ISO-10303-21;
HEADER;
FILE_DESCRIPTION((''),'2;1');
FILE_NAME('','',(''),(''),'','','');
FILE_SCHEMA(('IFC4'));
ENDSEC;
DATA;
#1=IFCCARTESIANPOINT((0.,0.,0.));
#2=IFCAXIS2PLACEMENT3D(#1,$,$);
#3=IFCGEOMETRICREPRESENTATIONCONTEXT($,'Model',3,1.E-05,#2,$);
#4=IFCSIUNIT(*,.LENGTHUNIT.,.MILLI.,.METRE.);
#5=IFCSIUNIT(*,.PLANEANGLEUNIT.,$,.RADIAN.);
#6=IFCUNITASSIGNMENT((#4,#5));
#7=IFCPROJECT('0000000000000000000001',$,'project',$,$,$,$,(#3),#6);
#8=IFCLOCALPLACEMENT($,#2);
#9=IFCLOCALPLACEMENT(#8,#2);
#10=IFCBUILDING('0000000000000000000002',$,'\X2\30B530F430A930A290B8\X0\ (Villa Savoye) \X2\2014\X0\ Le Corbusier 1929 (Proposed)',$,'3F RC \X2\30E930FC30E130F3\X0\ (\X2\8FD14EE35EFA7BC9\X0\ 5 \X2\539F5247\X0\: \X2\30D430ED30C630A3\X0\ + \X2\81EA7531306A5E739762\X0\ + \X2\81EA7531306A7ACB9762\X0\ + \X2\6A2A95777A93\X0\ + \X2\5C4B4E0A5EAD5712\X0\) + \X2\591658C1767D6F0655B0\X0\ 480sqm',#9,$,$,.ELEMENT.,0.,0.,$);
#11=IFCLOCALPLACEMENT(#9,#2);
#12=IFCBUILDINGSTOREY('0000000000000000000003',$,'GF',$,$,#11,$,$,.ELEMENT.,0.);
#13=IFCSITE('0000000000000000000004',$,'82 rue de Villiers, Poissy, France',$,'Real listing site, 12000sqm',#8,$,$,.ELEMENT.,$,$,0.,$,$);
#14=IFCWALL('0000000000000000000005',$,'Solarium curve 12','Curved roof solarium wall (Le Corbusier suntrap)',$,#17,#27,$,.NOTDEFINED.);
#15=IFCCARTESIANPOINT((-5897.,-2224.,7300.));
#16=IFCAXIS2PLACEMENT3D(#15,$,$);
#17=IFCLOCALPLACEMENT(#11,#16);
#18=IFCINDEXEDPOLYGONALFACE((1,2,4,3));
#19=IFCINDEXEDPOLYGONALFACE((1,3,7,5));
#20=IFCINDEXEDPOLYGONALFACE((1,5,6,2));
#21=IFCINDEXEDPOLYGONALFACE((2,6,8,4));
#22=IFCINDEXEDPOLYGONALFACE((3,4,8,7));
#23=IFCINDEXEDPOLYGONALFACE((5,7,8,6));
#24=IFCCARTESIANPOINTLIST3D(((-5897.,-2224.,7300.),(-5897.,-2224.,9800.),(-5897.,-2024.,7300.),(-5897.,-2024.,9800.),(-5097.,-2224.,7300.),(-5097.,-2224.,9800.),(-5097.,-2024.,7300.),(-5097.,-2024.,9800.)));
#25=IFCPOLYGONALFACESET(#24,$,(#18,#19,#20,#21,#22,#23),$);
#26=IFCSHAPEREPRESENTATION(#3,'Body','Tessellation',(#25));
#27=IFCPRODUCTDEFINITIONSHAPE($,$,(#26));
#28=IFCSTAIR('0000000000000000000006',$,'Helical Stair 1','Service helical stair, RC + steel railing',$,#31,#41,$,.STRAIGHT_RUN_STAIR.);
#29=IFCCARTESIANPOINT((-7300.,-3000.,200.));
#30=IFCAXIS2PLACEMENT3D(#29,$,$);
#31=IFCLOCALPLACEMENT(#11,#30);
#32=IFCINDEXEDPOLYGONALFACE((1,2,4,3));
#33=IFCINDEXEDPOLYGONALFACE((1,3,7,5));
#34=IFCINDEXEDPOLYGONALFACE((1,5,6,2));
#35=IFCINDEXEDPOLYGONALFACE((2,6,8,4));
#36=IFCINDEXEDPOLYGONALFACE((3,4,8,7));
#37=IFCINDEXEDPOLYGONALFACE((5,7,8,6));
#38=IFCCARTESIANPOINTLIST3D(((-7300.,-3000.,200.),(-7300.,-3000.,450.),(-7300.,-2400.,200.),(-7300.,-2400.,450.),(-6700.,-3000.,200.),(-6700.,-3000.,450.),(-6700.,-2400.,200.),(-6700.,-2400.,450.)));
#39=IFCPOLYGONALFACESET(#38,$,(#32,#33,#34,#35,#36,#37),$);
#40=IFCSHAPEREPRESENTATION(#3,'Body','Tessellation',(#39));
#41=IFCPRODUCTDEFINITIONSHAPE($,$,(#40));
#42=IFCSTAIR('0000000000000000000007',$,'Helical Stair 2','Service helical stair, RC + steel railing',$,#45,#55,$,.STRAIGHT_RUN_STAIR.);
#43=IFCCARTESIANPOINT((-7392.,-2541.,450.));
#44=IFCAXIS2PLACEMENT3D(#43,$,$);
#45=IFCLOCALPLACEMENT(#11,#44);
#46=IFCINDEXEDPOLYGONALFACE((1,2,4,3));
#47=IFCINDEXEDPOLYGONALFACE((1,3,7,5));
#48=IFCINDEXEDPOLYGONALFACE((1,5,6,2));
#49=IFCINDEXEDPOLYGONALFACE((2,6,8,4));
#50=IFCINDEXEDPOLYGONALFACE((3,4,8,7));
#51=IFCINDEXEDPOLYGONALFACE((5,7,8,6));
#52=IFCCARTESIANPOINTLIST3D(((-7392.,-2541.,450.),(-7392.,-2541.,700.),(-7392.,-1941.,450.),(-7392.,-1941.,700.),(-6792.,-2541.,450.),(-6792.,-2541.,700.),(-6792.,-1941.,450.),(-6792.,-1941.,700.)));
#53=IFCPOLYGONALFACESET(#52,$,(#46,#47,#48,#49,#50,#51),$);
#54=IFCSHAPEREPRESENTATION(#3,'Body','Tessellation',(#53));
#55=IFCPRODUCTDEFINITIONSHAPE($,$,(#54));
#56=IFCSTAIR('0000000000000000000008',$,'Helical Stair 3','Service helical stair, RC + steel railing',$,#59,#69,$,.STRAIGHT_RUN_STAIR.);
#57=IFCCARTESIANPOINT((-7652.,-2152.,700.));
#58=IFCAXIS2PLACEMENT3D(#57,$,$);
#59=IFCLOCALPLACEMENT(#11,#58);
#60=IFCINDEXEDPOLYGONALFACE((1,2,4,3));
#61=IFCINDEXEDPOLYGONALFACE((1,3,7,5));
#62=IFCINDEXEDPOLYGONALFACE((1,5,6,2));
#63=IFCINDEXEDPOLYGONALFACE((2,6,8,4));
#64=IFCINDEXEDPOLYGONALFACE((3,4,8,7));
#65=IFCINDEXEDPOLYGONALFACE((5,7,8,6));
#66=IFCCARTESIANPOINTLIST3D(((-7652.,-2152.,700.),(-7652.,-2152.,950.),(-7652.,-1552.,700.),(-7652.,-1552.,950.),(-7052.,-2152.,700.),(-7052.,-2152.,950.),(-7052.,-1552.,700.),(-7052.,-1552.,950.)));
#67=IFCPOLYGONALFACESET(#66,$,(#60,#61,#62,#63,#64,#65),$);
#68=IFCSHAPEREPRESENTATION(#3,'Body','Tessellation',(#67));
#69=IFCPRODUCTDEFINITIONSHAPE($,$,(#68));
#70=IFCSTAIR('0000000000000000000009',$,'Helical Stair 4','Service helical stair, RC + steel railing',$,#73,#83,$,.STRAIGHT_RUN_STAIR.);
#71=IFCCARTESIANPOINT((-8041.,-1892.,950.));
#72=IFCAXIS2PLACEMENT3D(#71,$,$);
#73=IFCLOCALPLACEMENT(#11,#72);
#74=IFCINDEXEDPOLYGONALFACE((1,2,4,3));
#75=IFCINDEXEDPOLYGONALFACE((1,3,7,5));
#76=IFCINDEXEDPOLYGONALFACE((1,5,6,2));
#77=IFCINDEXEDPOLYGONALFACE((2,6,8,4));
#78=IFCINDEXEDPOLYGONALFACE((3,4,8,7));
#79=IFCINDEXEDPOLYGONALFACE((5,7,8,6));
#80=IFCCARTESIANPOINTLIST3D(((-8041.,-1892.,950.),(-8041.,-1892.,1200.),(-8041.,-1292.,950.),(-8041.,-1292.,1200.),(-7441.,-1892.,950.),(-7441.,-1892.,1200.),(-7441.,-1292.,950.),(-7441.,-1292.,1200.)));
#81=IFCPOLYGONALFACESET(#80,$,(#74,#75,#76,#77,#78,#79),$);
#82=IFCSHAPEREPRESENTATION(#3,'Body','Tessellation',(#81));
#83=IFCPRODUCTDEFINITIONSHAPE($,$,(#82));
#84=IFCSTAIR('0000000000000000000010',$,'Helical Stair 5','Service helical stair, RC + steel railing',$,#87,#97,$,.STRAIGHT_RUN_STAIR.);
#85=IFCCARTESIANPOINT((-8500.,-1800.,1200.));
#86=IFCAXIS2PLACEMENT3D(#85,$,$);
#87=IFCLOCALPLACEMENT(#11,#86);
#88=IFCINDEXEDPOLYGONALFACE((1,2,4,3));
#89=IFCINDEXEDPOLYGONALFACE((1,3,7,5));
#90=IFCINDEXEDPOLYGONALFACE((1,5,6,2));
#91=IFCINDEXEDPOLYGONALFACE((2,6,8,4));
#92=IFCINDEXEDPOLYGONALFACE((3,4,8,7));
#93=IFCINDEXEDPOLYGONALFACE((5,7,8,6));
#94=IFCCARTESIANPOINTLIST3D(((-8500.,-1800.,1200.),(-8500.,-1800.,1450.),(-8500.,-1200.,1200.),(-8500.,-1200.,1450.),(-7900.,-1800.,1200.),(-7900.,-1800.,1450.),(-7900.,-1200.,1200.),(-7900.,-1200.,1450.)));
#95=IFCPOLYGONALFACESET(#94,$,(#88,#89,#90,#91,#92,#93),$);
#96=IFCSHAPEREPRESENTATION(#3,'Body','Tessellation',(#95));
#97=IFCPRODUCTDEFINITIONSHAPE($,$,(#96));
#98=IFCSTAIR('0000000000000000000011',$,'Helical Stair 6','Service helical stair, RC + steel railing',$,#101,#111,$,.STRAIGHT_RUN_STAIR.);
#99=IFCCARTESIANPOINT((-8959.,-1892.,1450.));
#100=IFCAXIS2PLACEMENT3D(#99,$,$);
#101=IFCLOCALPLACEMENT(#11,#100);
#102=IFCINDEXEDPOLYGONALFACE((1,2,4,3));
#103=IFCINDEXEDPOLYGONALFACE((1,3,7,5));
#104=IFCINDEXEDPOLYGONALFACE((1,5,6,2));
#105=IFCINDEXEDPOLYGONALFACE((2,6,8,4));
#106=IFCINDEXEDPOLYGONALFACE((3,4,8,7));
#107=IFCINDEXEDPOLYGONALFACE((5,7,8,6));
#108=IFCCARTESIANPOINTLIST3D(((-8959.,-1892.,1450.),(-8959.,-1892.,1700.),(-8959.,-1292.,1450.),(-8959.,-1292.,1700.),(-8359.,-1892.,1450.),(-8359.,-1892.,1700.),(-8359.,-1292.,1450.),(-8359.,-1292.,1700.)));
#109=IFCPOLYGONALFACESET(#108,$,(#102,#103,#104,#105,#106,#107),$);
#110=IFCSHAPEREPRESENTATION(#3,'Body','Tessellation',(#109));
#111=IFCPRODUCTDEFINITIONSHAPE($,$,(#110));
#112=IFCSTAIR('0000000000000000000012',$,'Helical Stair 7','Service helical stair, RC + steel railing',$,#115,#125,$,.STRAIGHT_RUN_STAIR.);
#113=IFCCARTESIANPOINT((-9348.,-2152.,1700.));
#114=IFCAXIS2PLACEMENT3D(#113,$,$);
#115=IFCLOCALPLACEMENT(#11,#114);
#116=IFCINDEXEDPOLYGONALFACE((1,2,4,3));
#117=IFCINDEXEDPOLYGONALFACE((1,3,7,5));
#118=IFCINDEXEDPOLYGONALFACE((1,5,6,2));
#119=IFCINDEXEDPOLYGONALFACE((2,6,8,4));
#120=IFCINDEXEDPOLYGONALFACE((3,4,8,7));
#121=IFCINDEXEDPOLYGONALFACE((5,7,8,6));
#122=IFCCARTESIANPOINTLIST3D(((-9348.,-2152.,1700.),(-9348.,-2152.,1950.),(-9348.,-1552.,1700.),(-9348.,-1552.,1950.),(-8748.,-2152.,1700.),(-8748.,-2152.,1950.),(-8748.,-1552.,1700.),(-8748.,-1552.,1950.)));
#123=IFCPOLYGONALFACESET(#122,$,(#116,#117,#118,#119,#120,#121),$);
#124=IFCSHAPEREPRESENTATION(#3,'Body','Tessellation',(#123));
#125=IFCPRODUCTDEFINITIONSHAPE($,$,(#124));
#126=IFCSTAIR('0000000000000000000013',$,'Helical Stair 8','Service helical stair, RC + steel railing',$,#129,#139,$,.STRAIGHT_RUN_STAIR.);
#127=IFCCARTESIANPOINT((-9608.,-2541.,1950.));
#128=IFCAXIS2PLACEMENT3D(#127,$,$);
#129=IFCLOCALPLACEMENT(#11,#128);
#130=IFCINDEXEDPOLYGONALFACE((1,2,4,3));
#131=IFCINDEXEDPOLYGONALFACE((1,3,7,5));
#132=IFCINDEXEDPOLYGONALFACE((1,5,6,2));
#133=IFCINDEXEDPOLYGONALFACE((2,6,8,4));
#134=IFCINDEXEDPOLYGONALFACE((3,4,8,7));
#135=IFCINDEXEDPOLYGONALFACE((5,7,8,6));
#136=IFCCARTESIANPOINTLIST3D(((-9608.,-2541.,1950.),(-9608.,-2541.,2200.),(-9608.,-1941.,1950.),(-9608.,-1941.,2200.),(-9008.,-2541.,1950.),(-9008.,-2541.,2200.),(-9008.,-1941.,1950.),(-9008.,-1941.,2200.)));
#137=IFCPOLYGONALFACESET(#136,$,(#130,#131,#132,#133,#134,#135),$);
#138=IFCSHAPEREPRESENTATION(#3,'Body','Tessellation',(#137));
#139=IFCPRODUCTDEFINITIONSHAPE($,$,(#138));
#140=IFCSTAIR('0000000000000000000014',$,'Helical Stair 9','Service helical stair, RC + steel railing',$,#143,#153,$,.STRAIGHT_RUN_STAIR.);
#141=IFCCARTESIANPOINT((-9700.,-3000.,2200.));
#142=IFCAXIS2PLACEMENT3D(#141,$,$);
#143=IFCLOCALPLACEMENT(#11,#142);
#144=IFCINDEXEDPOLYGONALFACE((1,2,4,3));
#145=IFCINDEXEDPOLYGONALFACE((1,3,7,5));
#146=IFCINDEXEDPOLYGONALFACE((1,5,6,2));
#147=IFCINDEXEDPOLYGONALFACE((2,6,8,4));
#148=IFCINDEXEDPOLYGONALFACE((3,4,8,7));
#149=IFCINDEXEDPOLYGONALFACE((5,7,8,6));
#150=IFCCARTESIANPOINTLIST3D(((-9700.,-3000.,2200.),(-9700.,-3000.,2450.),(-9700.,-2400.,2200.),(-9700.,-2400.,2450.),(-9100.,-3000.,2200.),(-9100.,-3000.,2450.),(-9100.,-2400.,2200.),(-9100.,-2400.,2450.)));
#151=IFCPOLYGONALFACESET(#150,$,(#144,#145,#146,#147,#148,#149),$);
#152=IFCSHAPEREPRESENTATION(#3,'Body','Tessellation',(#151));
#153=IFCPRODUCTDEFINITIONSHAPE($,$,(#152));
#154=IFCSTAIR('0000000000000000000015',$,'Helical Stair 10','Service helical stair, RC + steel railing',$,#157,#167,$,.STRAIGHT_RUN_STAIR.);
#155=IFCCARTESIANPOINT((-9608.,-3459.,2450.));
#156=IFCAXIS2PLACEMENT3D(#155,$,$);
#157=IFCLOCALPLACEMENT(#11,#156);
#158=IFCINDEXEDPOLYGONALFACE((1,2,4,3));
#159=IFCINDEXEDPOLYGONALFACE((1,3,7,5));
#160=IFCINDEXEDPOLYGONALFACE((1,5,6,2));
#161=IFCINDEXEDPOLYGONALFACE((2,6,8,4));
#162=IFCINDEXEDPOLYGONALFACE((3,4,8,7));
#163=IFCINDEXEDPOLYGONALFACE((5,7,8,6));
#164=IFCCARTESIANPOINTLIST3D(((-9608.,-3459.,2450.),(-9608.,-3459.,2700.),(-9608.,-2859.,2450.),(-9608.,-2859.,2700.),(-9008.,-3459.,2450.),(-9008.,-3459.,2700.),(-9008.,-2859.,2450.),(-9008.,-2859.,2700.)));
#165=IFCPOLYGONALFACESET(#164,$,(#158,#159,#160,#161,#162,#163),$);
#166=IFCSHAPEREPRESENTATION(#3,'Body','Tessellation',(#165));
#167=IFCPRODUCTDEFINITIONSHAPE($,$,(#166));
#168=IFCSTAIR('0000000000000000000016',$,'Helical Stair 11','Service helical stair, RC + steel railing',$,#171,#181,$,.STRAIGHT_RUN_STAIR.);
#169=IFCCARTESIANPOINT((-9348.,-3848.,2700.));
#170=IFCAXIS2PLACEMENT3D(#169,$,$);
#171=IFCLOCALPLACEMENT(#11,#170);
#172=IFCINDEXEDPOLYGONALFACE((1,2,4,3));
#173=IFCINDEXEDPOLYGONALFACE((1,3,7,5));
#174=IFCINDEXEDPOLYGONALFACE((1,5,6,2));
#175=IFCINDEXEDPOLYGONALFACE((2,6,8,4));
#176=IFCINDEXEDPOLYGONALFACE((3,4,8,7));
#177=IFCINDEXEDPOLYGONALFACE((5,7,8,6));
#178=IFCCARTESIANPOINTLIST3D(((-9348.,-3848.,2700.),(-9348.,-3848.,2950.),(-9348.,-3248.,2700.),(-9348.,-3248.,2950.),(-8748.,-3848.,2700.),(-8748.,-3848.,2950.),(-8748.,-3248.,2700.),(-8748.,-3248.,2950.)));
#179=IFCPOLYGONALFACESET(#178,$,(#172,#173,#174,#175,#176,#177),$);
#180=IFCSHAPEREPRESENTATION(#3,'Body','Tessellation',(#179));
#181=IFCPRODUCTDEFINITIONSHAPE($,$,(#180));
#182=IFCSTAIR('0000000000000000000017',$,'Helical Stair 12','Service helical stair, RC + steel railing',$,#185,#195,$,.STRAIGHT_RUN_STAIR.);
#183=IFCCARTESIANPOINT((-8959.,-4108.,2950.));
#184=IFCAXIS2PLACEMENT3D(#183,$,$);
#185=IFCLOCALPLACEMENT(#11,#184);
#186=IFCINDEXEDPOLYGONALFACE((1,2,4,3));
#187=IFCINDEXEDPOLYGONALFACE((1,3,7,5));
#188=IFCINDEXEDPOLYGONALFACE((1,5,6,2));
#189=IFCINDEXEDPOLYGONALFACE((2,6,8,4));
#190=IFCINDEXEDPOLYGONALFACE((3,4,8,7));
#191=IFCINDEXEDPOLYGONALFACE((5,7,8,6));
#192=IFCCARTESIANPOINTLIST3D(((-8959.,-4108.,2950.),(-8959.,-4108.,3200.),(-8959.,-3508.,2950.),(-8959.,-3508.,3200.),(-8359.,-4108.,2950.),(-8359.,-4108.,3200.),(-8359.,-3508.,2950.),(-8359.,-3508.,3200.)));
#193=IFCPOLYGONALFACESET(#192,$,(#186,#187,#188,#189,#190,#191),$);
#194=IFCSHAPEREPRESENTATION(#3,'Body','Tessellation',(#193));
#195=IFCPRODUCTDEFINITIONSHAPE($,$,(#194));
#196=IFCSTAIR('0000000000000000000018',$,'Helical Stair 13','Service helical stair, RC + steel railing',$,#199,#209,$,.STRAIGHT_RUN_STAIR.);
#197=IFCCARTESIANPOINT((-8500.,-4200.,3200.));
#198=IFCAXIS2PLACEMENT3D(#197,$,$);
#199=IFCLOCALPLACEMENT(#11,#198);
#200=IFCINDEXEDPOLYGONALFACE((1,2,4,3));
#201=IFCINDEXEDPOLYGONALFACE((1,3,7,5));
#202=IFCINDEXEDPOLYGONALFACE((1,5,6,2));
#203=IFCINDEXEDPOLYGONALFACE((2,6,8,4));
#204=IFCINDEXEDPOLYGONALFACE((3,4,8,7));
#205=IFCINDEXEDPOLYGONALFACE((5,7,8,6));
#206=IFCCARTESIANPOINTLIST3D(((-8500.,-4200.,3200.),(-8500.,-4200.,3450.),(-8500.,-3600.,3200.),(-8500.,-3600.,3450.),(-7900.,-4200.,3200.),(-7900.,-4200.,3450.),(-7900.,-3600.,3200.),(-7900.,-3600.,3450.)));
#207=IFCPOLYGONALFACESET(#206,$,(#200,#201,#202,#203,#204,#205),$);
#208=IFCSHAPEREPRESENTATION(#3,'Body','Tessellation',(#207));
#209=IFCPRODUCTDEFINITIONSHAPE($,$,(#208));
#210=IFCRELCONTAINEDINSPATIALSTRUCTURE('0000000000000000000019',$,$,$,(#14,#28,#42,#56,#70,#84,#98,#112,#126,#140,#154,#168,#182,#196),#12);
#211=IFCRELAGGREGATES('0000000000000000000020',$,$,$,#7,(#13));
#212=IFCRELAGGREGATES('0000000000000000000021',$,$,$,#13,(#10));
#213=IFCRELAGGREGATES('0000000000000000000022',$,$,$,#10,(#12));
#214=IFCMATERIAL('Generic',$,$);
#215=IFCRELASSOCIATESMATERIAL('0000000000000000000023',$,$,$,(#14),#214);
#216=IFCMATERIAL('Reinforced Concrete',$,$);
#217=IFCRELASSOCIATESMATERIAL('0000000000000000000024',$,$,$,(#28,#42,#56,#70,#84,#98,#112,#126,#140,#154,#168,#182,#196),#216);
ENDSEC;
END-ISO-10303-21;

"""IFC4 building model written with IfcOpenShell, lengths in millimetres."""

from ifc_helpers import new_model, si_unit, frame, frame_2d, origin, place, context, project, spatial, rectangle, extrude, material, element, save


model = new_model("IFC4")

# Units and contexts
model_context = context("Model", 3, precision=1e-05, world=origin())
ifc_project = project(units=[si_unit("LENGTHUNIT", "METRE", prefix="MILLI"), si_unit("PLANEANGLEUNIT", "RADIAN")], contexts=[model_context])

# Site, building, storey
site_placement = place(None, origin())
site = spatial("IfcSite", under=ifc_project, at=site_placement, Name="82 rue de Villiers, Poissy, France", ObjectType="Real listing site, 12000sqm", CompositionType="ELEMENT", RefElevation=0.0)
building_placement = place(site_placement, origin())
building = spatial("IfcBuilding", under=site, at=building_placement, Name="サヴォア邸 (Villa Savoye) — Le Corbusier 1929 (Proposed)", ObjectType="3F RC ラーメン (近代建築 5 原則: ピロティ + 自由な平面 + 自由な立面 + 横長窓 + 屋上庭園) + 外壁白漆喰 480sqm", CompositionType="ELEMENT", ElevationOfRefHeight=0.0, ElevationOfTerrain=0.0)
storey_placement = place(building_placement, origin())
storey = spatial("IfcBuildingStorey", under=building, at=storey_placement, Name="GF", CompositionType="ELEMENT", Elevation=0.0)

# Shared definitions
ifc_material_1 = material(Name="Reinforced Concrete")
ifc_material_2 = material(Name="Generic")

# Wall
wall_1_placement = place(storey_placement, frame((-5897.0, -2224.0, 7300.0)))
element("IfcWall", 1, at=wall_1_placement, inside=storey, material=ifc_material_2, Name="Solarium curve 12", Description="Curved roof solarium wall (Le Corbusier suntrap)", PredefinedType="NOTDEFINED", context=model_context, shape_type="SweptSolid", body=[
    extrude(rectangle(XDim=800.0, YDim=200.0, at=frame_2d((400.0, 100.0))), frame((-5897.0, -2224.0, 7300.0)), (0.0, 0.0, 1.0), 2500.0),
])

# Stairs
stair_1_placement = place(storey_placement, frame((-7300.0, -3000.0, 200.0)))
element("IfcStair", 2, at=stair_1_placement, inside=storey, material=ifc_material_1, Name="Helical Stair 1", Description="Service helical stair, RC + steel railing", PredefinedType="STRAIGHT_RUN_STAIR", context=model_context, shape_type="SweptSolid", body=[
    extrude(rectangle(XDim=600.0, YDim=600.0, at=frame_2d((300.0, 300.0))), frame((-7300.0, -3000.0, 200.0)), (0.0, 0.0, 1.0), 250.0),
])
stair_2_placement = place(storey_placement, frame((-7392.0, -2541.0, 450.0)))
element("IfcStair", 3, at=stair_2_placement, inside=storey, material=ifc_material_1, Name="Helical Stair 2", Description="Service helical stair, RC + steel railing", PredefinedType="STRAIGHT_RUN_STAIR", context=model_context, shape_type="SweptSolid", body=[
    extrude(rectangle(XDim=600.0, YDim=600.0, at=frame_2d((300.0, 300.0))), frame((-7392.0, -2541.0, 450.0)), (0.0, 0.0, 1.0), 250.0),
])
stair_3_placement = place(storey_placement, frame((-7652.0, -2152.0, 700.0)))
element("IfcStair", 4, at=stair_3_placement, inside=storey, material=ifc_material_1, Name="Helical Stair 3", Description="Service helical stair, RC + steel railing", PredefinedType="STRAIGHT_RUN_STAIR", context=model_context, shape_type="SweptSolid", body=[
    extrude(rectangle(XDim=600.0, YDim=600.0, at=frame_2d((300.0, 300.0))), frame((-7652.0, -2152.0, 700.0)), (0.0, 0.0, 1.0), 250.0),
])
stair_4_placement = place(storey_placement, frame((-8041.0, -1892.0, 950.0)))
element("IfcStair", 5, at=stair_4_placement, inside=storey, material=ifc_material_1, Name="Helical Stair 4", Description="Service helical stair, RC + steel railing", PredefinedType="STRAIGHT_RUN_STAIR", context=model_context, shape_type="SweptSolid", body=[
    extrude(rectangle(XDim=600.0, YDim=600.0, at=frame_2d((300.0, 300.0))), frame((-8041.0, -1892.0, 950.0)), (0.0, 0.0, 1.0), 250.0),
])
stair_5_placement = place(storey_placement, frame((-8500.0, -1800.0, 1200.0)))
element("IfcStair", 6, at=stair_5_placement, inside=storey, material=ifc_material_1, Name="Helical Stair 5", Description="Service helical stair, RC + steel railing", PredefinedType="STRAIGHT_RUN_STAIR", context=model_context, shape_type="SweptSolid", body=[
    extrude(rectangle(XDim=600.0, YDim=600.0, at=frame_2d((300.0, 300.0))), frame((-8500.0, -1800.0, 1200.0)), (0.0, 0.0, 1.0), 250.0),
])
stair_6_placement = place(storey_placement, frame((-8959.0, -1892.0, 1450.0)))
element("IfcStair", 7, at=stair_6_placement, inside=storey, material=ifc_material_1, Name="Helical Stair 6", Description="Service helical stair, RC + steel railing", PredefinedType="STRAIGHT_RUN_STAIR", context=model_context, shape_type="SweptSolid", body=[
    extrude(rectangle(XDim=600.0, YDim=600.0, at=frame_2d((300.0, 300.0))), frame((-8959.0, -1892.0, 1450.0)), (0.0, 0.0, 1.0), 250.0),
])
stair_7_placement = place(storey_placement, frame((-9348.0, -2152.0, 1700.0)))
element("IfcStair", 8, at=stair_7_placement, inside=storey, material=ifc_material_1, Name="Helical Stair 7", Description="Service helical stair, RC + steel railing", PredefinedType="STRAIGHT_RUN_STAIR", context=model_context, shape_type="SweptSolid", body=[
    extrude(rectangle(XDim=600.0, YDim=600.0, at=frame_2d((300.0, 300.0))), frame((-9348.0, -2152.0, 1700.0)), (0.0, 0.0, 1.0), 250.0),
])
stair_8_placement = place(storey_placement, frame((-9608.0, -2541.0, 1950.0)))
element("IfcStair", 9, at=stair_8_placement, inside=storey, material=ifc_material_1, Name="Helical Stair 8", Description="Service helical stair, RC + steel railing", PredefinedType="STRAIGHT_RUN_STAIR", context=model_context, shape_type="SweptSolid", body=[
    extrude(rectangle(XDim=600.0, YDim=600.0, at=frame_2d((300.0, 300.0))), frame((-9608.0, -2541.0, 1950.0)), (0.0, 0.0, 1.0), 250.0),
])
stair_9_placement = place(storey_placement, frame((-9700.0, -3000.0, 2200.0)))
element("IfcStair", 10, at=stair_9_placement, inside=storey, material=ifc_material_1, Name="Helical Stair 9", Description="Service helical stair, RC + steel railing", PredefinedType="STRAIGHT_RUN_STAIR", context=model_context, shape_type="SweptSolid", body=[
    extrude(rectangle(XDim=600.0, YDim=600.0, at=frame_2d((300.0, 300.0))), frame((-9700.0, -3000.0, 2200.0)), (0.0, 0.0, 1.0), 250.0),
])
stair_10_placement = place(storey_placement, frame((-9608.0, -3459.0, 2450.0)))
element("IfcStair", 11, at=stair_10_placement, inside=storey, material=ifc_material_1, Name="Helical Stair 10", Description="Service helical stair, RC + steel railing", PredefinedType="STRAIGHT_RUN_STAIR", context=model_context, shape_type="SweptSolid", body=[
    extrude(rectangle(XDim=600.0, YDim=600.0, at=frame_2d((300.0, 300.0))), frame((-9608.0, -3459.0, 2450.0)), (0.0, 0.0, 1.0), 250.0),
])
stair_11_placement = place(storey_placement, frame((-9348.0, -3848.0, 2700.0)))
element("IfcStair", 12, at=stair_11_placement, inside=storey, material=ifc_material_1, Name="Helical Stair 11", Description="Service helical stair, RC + steel railing", PredefinedType="STRAIGHT_RUN_STAIR", context=model_context, shape_type="SweptSolid", body=[
    extrude(rectangle(XDim=600.0, YDim=600.0, at=frame_2d((300.0, 300.0))), frame((-9348.0, -3848.0, 2700.0)), (0.0, 0.0, 1.0), 250.0),
])
stair_12_placement = place(storey_placement, frame((-8959.0, -4108.0, 2950.0)))
element("IfcStair", 13, at=stair_12_placement, inside=storey, material=ifc_material_1, Name="Helical Stair 12", Description="Service helical stair, RC + steel railing", PredefinedType="STRAIGHT_RUN_STAIR", context=model_context, shape_type="SweptSolid", body=[
    extrude(rectangle(XDim=600.0, YDim=600.0, at=frame_2d((300.0, 300.0))), frame((-8959.0, -4108.0, 2950.0)), (0.0, 0.0, 1.0), 250.0),
])
stair_13_placement = place(storey_placement, frame((-8500.0, -4200.0, 3200.0)))
element("IfcStair", 14, at=stair_13_placement, inside=storey, material=ifc_material_1, Name="Helical Stair 13", Description="Service helical stair, RC + steel railing", PredefinedType="STRAIGHT_RUN_STAIR", context=model_context, shape_type="SweptSolid", body=[
    extrude(rectangle(XDim=600.0, YDim=600.0, at=frame_2d((300.0, 300.0))), frame((-8500.0, -4200.0, 3200.0)), (0.0, 0.0, 1.0), 250.0),
])

save(model, "model.ifc")
